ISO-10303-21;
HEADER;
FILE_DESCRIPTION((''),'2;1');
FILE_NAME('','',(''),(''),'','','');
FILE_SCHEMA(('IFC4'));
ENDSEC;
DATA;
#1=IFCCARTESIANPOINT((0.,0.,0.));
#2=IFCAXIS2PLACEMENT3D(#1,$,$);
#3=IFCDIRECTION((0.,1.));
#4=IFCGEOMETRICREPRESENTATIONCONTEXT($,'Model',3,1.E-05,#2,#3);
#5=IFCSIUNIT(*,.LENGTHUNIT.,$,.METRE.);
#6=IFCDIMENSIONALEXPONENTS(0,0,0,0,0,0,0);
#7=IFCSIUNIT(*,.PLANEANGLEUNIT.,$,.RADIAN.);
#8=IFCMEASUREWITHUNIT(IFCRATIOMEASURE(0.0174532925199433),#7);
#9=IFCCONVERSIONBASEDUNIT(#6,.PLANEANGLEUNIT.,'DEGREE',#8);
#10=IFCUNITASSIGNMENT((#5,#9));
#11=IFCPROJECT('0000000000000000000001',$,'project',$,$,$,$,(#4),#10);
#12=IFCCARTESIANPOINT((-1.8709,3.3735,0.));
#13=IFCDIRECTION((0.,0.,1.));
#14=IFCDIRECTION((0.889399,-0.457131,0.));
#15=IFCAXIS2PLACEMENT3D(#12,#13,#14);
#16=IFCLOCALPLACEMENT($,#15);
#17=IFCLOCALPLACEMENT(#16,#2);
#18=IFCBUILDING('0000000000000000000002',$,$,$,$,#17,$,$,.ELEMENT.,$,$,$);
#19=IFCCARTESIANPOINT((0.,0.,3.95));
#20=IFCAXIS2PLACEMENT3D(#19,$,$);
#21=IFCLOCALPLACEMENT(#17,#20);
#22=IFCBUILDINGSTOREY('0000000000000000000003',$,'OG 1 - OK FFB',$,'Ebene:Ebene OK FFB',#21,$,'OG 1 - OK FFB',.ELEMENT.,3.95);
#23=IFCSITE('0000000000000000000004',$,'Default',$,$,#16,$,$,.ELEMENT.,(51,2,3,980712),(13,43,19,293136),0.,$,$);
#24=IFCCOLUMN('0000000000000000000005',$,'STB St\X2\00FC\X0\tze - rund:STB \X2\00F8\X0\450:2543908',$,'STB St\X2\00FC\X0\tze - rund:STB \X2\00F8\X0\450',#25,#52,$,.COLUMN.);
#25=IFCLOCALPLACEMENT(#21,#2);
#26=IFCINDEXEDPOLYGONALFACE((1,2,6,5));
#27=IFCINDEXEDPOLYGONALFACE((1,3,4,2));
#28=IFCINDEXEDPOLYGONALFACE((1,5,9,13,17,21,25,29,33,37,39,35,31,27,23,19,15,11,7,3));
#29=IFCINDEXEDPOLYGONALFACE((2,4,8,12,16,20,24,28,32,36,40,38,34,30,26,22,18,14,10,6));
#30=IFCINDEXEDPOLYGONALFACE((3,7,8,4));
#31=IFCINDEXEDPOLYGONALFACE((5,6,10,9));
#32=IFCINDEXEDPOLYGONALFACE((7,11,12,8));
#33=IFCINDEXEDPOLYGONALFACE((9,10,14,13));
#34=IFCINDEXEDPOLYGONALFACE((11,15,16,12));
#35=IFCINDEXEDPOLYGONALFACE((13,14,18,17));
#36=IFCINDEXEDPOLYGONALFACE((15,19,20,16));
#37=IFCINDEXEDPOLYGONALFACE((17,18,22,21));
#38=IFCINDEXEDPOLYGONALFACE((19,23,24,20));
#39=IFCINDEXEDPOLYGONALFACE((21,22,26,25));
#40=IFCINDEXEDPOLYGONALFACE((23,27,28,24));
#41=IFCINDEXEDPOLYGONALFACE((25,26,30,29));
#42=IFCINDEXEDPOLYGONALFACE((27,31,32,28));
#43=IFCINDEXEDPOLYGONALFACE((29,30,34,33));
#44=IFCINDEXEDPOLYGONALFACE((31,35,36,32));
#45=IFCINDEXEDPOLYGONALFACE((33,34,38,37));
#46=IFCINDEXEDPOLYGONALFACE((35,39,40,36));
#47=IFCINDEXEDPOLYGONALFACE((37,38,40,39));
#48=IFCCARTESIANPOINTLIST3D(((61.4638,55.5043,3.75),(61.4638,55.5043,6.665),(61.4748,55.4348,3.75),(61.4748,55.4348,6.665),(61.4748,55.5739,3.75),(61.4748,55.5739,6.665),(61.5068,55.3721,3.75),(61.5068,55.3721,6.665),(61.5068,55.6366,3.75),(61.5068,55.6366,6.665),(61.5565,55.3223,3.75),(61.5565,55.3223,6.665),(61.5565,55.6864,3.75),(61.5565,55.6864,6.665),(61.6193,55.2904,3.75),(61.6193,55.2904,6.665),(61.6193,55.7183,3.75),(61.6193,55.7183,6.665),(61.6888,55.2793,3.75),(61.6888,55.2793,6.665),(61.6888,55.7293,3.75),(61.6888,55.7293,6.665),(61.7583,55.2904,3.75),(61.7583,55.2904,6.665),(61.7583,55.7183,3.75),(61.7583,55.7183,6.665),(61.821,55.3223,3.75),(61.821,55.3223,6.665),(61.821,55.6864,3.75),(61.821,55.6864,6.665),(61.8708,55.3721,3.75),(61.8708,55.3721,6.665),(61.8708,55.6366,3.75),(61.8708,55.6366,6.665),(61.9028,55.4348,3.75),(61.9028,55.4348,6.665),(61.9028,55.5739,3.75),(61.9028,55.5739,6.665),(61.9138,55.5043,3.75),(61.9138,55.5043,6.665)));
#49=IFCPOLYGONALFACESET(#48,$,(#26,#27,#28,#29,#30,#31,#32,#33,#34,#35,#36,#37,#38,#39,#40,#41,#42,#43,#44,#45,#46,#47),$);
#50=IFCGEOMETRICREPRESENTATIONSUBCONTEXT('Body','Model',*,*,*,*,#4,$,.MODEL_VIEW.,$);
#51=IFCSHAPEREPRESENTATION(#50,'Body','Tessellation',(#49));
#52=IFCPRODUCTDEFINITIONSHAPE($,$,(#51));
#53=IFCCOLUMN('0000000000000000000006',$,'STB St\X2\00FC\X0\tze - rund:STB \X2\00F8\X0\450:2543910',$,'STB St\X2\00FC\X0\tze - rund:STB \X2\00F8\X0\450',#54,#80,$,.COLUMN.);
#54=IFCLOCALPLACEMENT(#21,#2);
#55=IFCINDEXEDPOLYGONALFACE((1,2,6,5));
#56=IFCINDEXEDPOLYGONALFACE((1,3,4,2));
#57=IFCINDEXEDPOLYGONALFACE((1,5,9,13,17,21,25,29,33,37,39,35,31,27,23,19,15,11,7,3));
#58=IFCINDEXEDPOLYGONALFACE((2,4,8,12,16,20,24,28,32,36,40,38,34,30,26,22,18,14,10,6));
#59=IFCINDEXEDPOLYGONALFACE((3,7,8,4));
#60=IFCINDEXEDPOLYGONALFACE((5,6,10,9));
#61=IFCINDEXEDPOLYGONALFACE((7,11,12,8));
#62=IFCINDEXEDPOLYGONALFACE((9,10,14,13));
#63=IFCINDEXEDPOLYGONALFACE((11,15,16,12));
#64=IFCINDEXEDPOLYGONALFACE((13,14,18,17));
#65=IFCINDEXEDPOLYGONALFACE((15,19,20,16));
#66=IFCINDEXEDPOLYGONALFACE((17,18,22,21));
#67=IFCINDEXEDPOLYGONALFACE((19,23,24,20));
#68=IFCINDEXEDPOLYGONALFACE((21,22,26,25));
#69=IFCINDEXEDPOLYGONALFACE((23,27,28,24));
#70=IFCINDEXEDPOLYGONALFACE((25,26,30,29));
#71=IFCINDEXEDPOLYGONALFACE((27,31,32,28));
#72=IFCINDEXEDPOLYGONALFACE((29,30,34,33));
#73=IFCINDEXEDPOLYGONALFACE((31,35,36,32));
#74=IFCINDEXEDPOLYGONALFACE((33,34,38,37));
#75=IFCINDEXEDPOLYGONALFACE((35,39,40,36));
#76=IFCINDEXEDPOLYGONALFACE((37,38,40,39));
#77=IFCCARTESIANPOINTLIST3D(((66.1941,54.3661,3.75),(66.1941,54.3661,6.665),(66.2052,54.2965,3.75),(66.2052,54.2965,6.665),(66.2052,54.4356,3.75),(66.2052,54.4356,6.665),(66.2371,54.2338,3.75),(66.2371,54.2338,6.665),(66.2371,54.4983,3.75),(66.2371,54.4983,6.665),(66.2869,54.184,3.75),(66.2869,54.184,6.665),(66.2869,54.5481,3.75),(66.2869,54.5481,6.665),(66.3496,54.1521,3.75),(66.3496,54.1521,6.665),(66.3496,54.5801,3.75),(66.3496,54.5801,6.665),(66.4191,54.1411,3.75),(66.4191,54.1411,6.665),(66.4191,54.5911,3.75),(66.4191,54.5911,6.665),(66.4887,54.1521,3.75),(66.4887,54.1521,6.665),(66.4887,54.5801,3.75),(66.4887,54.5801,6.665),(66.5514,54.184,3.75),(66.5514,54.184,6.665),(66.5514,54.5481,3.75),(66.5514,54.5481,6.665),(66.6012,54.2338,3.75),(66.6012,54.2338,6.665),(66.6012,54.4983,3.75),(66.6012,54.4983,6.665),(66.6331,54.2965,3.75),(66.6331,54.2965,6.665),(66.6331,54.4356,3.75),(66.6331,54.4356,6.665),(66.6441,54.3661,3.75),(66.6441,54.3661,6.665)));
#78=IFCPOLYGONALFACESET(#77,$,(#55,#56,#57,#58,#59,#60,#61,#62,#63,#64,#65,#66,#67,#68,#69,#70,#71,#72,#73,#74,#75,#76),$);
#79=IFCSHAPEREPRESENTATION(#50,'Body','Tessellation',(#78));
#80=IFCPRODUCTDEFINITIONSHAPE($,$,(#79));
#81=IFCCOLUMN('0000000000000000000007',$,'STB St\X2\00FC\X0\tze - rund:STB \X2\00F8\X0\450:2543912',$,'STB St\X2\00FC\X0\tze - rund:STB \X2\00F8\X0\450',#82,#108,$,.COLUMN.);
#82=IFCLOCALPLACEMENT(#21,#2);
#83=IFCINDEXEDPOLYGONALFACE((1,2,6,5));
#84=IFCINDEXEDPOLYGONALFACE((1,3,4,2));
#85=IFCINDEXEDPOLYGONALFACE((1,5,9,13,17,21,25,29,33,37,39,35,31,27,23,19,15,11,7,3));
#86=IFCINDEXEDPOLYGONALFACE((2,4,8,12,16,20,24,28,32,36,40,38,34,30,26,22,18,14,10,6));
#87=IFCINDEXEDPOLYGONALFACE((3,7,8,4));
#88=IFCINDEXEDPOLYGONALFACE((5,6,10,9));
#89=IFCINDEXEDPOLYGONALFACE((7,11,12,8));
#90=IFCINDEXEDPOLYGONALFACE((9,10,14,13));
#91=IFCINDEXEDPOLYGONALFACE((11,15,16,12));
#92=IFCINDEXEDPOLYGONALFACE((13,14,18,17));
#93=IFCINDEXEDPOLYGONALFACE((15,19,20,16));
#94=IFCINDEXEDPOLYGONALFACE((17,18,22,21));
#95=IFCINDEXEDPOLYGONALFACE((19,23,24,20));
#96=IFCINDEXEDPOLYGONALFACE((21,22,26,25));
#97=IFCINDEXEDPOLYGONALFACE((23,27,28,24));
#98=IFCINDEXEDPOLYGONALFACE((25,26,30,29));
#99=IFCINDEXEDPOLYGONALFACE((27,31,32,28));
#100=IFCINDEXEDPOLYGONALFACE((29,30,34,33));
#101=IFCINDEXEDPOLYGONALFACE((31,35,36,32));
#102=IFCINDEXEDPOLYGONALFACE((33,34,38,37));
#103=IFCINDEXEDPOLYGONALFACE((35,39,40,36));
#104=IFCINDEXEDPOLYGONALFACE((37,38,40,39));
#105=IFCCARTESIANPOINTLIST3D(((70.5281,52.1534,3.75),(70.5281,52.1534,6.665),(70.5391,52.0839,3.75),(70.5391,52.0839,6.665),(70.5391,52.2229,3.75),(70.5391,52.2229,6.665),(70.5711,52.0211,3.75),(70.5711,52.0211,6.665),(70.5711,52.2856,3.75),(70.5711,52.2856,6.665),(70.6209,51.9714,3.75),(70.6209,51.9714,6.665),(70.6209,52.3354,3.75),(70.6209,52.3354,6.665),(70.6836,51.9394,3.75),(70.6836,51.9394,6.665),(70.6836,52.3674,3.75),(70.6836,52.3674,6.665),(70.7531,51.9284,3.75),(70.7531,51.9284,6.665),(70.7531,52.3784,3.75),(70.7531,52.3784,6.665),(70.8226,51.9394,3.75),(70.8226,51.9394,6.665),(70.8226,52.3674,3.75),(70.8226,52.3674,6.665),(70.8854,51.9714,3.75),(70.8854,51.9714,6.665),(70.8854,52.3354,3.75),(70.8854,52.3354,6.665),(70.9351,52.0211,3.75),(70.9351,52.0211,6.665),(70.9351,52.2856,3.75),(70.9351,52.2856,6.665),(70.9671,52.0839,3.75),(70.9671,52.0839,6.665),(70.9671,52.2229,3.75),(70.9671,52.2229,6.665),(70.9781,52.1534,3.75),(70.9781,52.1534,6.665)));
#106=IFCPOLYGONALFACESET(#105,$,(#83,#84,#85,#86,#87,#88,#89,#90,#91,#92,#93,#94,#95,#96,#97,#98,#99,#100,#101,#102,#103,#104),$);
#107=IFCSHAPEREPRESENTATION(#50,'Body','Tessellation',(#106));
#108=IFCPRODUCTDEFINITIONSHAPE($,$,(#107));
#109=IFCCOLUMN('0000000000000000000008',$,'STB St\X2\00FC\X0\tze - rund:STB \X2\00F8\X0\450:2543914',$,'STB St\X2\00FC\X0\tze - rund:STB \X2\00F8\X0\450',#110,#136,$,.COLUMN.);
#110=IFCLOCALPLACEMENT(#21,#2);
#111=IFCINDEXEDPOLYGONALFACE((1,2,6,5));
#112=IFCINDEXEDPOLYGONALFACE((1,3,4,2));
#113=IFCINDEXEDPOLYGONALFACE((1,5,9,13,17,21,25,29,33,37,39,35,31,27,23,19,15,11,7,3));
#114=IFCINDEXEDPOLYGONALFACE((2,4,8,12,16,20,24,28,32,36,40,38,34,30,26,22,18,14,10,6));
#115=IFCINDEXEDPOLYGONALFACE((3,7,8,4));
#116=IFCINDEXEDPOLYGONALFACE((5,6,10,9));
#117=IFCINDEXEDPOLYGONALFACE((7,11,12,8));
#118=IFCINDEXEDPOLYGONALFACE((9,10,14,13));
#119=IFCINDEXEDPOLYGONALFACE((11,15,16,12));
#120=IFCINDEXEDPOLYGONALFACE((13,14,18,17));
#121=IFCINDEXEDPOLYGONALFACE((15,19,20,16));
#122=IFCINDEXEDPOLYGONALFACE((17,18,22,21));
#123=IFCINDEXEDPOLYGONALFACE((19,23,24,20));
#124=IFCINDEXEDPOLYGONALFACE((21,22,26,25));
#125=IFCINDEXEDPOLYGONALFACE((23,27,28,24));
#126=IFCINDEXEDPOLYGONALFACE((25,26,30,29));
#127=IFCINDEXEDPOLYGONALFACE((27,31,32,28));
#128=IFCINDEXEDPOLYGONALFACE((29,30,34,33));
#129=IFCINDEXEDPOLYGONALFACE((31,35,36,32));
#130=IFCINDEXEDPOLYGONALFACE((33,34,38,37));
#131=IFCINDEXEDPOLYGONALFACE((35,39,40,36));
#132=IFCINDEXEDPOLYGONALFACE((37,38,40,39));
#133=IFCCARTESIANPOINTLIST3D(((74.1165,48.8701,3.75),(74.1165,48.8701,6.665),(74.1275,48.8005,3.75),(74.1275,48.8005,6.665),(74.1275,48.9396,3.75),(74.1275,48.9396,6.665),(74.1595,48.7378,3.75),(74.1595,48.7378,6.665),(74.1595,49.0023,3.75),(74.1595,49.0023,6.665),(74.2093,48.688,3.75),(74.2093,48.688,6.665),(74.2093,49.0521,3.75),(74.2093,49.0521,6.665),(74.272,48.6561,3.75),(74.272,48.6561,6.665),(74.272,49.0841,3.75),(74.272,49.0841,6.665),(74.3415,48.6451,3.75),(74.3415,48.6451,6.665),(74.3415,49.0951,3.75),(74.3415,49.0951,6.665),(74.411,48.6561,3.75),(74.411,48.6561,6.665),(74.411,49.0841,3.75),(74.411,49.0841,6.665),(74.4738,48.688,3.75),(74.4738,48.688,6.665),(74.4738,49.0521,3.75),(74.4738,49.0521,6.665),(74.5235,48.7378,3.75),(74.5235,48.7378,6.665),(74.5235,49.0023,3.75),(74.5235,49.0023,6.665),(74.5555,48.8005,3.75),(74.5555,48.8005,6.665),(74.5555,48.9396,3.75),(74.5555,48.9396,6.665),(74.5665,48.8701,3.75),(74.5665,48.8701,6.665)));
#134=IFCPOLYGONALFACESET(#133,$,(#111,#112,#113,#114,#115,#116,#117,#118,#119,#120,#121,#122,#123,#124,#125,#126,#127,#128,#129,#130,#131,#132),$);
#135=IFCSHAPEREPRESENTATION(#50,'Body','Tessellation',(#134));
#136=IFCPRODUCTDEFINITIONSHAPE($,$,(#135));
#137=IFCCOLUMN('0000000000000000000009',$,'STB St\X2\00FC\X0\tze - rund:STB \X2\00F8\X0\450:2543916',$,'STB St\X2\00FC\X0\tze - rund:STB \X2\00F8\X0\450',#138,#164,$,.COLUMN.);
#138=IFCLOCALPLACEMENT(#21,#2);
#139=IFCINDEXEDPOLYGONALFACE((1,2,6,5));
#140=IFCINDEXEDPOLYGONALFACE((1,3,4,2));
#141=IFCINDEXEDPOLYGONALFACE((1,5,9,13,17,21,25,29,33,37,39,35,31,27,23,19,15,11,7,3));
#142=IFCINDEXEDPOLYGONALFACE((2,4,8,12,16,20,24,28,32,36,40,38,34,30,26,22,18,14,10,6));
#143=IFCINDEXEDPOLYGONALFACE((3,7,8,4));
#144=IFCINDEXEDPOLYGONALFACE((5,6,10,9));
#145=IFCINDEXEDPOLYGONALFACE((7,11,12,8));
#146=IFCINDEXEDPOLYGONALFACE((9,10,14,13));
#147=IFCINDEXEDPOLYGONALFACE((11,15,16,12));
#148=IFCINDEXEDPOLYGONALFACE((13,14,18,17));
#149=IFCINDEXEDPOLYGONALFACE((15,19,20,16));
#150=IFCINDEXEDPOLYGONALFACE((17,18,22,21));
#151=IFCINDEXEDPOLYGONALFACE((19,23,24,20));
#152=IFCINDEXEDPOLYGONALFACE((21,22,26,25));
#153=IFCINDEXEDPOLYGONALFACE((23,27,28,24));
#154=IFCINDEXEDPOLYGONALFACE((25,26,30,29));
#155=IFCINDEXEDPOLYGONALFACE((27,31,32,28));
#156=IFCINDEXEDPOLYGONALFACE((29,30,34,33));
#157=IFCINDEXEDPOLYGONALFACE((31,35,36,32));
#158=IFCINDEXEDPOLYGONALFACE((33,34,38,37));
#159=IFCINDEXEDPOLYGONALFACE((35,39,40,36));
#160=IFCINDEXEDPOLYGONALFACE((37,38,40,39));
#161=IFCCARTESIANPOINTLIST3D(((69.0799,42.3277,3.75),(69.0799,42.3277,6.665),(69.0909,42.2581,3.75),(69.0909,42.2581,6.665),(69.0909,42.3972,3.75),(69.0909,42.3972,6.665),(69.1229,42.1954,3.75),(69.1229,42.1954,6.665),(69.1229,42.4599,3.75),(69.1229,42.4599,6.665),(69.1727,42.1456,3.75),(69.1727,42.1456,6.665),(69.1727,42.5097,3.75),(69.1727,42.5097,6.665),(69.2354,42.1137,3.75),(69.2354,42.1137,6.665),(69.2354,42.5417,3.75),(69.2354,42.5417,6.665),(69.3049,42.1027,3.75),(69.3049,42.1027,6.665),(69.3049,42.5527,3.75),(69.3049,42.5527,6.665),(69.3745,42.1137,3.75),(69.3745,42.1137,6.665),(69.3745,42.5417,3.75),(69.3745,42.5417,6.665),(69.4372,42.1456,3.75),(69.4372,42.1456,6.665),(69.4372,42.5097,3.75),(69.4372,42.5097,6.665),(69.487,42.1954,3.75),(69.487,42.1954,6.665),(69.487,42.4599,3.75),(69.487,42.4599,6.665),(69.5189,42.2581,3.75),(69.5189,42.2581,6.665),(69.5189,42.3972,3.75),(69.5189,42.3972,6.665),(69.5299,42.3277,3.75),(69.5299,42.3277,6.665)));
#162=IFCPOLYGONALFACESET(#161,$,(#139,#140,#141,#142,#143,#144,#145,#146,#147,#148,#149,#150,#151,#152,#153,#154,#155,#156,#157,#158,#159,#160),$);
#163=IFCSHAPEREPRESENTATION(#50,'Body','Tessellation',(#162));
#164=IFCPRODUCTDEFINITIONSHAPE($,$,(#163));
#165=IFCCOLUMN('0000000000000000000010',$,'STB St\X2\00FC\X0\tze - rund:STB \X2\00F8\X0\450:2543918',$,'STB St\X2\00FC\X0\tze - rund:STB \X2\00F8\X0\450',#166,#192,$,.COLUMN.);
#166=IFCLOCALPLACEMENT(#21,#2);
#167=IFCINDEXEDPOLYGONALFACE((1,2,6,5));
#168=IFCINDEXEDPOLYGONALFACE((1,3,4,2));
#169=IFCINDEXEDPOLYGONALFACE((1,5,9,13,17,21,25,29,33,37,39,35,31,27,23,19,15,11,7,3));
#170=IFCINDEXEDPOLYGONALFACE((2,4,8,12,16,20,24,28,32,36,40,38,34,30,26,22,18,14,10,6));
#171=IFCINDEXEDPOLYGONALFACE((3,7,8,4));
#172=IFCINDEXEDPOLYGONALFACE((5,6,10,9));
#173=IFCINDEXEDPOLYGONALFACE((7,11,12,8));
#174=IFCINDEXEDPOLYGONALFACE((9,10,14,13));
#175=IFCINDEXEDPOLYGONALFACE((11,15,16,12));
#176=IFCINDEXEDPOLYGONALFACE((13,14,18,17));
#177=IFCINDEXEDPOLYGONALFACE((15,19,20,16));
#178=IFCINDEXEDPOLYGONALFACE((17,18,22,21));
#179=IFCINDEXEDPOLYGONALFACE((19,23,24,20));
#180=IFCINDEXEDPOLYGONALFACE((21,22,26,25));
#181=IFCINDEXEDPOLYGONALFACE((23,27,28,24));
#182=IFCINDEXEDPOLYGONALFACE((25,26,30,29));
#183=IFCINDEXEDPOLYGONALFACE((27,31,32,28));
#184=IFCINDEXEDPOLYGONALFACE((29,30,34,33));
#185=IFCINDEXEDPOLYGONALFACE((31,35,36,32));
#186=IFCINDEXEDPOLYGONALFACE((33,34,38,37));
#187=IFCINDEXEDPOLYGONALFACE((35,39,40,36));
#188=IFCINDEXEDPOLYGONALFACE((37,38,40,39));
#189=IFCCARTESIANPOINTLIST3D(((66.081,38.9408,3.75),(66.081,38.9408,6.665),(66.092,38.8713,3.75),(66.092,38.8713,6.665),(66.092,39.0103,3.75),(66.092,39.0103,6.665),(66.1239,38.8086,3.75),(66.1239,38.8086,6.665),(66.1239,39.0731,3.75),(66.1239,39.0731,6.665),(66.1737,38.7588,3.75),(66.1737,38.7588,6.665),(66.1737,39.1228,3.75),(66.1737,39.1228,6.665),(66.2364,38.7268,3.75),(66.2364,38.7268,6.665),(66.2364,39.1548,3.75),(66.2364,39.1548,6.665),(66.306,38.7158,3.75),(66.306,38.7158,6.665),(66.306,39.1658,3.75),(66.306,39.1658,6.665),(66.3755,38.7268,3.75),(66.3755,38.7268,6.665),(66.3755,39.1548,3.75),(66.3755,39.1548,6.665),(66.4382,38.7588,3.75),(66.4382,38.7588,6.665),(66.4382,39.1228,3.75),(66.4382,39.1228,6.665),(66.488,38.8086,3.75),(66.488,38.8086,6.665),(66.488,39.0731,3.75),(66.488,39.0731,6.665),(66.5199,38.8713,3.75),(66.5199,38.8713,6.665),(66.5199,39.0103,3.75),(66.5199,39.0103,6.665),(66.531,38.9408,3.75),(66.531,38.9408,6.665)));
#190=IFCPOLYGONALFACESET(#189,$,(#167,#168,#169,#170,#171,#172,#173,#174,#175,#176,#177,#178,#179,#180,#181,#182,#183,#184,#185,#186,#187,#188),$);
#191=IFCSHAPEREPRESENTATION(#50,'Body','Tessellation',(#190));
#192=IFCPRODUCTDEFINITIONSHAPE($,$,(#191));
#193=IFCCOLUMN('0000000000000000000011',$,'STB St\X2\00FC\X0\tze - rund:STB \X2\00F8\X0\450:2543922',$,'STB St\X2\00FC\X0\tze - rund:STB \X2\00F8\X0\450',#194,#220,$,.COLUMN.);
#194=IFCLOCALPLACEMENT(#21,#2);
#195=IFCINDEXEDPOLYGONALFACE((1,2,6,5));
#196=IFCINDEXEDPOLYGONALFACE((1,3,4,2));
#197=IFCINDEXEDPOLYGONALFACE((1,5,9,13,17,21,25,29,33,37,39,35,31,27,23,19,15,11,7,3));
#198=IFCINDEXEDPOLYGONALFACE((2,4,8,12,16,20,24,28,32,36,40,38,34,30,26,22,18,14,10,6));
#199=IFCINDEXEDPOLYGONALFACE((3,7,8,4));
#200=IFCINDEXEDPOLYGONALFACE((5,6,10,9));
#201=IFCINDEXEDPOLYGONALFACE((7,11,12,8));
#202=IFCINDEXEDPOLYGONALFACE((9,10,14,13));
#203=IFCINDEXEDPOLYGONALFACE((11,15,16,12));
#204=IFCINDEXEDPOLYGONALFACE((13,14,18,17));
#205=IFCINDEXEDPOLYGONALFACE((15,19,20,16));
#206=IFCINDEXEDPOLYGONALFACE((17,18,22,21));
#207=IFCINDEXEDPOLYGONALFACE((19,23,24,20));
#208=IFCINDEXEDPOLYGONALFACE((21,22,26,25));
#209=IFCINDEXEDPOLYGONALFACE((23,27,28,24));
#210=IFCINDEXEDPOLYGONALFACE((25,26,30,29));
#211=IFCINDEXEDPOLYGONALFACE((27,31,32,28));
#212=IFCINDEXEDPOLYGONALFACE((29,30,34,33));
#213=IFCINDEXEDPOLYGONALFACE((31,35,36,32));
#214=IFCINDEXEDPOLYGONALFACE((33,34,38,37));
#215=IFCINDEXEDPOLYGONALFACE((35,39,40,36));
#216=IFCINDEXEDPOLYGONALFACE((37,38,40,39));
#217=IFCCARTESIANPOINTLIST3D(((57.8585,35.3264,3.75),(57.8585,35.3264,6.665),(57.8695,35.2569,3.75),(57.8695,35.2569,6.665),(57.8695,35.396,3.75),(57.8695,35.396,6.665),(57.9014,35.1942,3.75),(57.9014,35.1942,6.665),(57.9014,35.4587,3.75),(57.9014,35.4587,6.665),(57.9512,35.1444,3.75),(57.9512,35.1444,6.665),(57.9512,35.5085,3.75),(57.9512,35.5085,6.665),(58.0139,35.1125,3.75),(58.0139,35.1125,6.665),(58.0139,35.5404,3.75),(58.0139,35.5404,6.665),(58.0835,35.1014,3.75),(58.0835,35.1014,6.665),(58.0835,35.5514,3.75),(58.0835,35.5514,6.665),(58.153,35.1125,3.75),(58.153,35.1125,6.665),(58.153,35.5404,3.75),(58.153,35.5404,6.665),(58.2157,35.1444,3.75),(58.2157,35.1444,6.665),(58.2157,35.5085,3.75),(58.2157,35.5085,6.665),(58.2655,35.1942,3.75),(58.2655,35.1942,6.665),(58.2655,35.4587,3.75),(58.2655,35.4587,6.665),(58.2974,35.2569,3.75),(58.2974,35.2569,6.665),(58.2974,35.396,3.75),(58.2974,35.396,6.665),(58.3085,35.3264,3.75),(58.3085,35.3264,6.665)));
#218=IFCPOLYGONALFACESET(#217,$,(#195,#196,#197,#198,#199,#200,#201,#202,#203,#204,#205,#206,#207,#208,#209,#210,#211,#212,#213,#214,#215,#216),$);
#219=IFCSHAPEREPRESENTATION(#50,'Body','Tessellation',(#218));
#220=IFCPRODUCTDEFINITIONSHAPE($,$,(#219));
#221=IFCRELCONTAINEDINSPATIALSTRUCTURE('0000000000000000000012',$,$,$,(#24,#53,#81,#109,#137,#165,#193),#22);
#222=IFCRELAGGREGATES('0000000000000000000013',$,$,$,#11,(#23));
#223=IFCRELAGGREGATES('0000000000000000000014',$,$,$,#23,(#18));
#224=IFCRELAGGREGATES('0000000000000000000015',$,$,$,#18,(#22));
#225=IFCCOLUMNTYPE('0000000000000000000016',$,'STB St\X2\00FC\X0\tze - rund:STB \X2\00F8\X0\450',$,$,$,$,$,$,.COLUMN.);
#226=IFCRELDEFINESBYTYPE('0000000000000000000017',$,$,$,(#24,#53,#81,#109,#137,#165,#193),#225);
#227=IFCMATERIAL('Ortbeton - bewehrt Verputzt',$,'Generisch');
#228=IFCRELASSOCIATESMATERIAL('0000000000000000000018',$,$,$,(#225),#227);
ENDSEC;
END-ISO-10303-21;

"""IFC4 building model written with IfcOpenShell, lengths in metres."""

from ifc_helpers import new_model, entity, si_unit, converted_unit, direction, frame, origin, place, context, subcontext, project, spatial, indexed_curve, outline, extrude, source, transform, mapped, material, type_object, type_shapes, element, save


model = new_model("IFC4")

# Units and contexts
model_context = context("Model", 3, precision=1e-05, world=origin(), true_north=direction((0.0, 1.0)))
body_context = subcontext(model_context, "Body", "Model", "MODEL_VIEW")
ifc_project = project(units=[si_unit("LENGTHUNIT", "METRE"), converted_unit("PLANEANGLEUNIT", "DEGREE", entity("IfcRatioMeasure", 0.0174532925199433), si_unit("PLANEANGLEUNIT", "RADIAN"), dimensions=[0, 0, 0, 0, 0, 0, 0])], contexts=[model_context])

# Site, building, storey
site_placement = place(None, frame((-1.8709, 3.3735, 0.0), z_axis=(0.0, 0.0, 1.0), x_axis=(0.889399, -0.457131, 0.0)))
site = spatial("IfcSite", under=ifc_project, at=site_placement, Name="Default", CompositionType="ELEMENT", RefLatitude=(51, 2, 3, 980712), RefLongitude=(13, 43, 19, 293136), RefElevation=0.0)
building_placement = place(site_placement, origin())
building = spatial("IfcBuilding", under=site, at=building_placement, CompositionType="ELEMENT")
storey_placement = place(building_placement, frame((0.0, 0.0, 3.95)))
storey = spatial("IfcBuildingStorey", under=building, at=storey_placement, Name="OG 1 - OK FFB", ObjectType="Ebene:Ebene OK FFB", LongName="OG 1 - OK FFB", CompositionType="ELEMENT", Elevation=3.95)

# Columns
ifc_material_1 = material(Name="Ortbeton - bewehrt Verputzt", Category="Generisch")
column_type_1 = type_object("IfcColumnType", Name="STB Stütze - rund:STB ø450", PredefinedType="COLUMN", material=ifc_material_1)
shared_shape_1 = source(origin(), body_context, "Body", "SweptSolid", [
    extrude(outline(indexed_curve([(0.225, 0.0), (0.214, 0.0695), (0.182, 0.1323), (0.1323, 0.182), (0.0695, 0.214), (0.0, 0.225), (-0.0695, 0.214), (-0.1323, 0.182), (-0.182, 0.1323), (-0.214, 0.0695), (-0.225, 0.0), (-0.214, -0.0695), (-0.182, -0.1323), (-0.1323, -0.182), (-0.0695, -0.214), (0.0, -0.225), (0.0695, -0.214), (0.1323, -0.182), (0.182, -0.1323), (0.214, -0.0695), (0.225, 0.0)], self_intersect=False)), frame((0.0, 0.0, 7.7), z_axis=(0.0, 0.0, 1.0), x_axis=(-1.0, 0.0, 0.0)), (0.0, 0.0, 1.0), 2.915),
])
type_shapes(column_type_1, [shared_shape_1])
for number, where, name in (
    (1, (61.6888, 55.5043, -3.95), "STB Stütze - rund:STB ø450:2543908"),
    (2, (66.4191, 54.3661, -3.95), "STB Stütze - rund:STB ø450:2543910"),
    (3, (70.7531, 52.1534, -3.95), "STB Stütze - rund:STB ø450:2543912"),
    (4, (74.3415, 48.8701, -3.95), "STB Stütze - rund:STB ø450:2543914"),
    (5, (69.3049, 42.3277, -3.95), "STB Stütze - rund:STB ø450:2543916"),
    (6, (66.306, 38.9408, -3.95), "STB Stütze - rund:STB ø450:2543918"),
    (7, (58.0835, 35.3264, -3.95), "STB Stütze - rund:STB ø450:2543922"),
):
    element("IfcColumn", number, at=place(storey_placement, frame(where)), inside=storey, type_object=column_type_1, Name=name, ObjectType="STB Stütze - rund:STB ø450", PredefinedType="COLUMN", context=body_context, shape_type="MappedRepresentation", body=[
        mapped(shared_shape_1, transform((0.0, 0.0, 0.0), scale=1.0)),
    ])

save(model, "model.ifc")
